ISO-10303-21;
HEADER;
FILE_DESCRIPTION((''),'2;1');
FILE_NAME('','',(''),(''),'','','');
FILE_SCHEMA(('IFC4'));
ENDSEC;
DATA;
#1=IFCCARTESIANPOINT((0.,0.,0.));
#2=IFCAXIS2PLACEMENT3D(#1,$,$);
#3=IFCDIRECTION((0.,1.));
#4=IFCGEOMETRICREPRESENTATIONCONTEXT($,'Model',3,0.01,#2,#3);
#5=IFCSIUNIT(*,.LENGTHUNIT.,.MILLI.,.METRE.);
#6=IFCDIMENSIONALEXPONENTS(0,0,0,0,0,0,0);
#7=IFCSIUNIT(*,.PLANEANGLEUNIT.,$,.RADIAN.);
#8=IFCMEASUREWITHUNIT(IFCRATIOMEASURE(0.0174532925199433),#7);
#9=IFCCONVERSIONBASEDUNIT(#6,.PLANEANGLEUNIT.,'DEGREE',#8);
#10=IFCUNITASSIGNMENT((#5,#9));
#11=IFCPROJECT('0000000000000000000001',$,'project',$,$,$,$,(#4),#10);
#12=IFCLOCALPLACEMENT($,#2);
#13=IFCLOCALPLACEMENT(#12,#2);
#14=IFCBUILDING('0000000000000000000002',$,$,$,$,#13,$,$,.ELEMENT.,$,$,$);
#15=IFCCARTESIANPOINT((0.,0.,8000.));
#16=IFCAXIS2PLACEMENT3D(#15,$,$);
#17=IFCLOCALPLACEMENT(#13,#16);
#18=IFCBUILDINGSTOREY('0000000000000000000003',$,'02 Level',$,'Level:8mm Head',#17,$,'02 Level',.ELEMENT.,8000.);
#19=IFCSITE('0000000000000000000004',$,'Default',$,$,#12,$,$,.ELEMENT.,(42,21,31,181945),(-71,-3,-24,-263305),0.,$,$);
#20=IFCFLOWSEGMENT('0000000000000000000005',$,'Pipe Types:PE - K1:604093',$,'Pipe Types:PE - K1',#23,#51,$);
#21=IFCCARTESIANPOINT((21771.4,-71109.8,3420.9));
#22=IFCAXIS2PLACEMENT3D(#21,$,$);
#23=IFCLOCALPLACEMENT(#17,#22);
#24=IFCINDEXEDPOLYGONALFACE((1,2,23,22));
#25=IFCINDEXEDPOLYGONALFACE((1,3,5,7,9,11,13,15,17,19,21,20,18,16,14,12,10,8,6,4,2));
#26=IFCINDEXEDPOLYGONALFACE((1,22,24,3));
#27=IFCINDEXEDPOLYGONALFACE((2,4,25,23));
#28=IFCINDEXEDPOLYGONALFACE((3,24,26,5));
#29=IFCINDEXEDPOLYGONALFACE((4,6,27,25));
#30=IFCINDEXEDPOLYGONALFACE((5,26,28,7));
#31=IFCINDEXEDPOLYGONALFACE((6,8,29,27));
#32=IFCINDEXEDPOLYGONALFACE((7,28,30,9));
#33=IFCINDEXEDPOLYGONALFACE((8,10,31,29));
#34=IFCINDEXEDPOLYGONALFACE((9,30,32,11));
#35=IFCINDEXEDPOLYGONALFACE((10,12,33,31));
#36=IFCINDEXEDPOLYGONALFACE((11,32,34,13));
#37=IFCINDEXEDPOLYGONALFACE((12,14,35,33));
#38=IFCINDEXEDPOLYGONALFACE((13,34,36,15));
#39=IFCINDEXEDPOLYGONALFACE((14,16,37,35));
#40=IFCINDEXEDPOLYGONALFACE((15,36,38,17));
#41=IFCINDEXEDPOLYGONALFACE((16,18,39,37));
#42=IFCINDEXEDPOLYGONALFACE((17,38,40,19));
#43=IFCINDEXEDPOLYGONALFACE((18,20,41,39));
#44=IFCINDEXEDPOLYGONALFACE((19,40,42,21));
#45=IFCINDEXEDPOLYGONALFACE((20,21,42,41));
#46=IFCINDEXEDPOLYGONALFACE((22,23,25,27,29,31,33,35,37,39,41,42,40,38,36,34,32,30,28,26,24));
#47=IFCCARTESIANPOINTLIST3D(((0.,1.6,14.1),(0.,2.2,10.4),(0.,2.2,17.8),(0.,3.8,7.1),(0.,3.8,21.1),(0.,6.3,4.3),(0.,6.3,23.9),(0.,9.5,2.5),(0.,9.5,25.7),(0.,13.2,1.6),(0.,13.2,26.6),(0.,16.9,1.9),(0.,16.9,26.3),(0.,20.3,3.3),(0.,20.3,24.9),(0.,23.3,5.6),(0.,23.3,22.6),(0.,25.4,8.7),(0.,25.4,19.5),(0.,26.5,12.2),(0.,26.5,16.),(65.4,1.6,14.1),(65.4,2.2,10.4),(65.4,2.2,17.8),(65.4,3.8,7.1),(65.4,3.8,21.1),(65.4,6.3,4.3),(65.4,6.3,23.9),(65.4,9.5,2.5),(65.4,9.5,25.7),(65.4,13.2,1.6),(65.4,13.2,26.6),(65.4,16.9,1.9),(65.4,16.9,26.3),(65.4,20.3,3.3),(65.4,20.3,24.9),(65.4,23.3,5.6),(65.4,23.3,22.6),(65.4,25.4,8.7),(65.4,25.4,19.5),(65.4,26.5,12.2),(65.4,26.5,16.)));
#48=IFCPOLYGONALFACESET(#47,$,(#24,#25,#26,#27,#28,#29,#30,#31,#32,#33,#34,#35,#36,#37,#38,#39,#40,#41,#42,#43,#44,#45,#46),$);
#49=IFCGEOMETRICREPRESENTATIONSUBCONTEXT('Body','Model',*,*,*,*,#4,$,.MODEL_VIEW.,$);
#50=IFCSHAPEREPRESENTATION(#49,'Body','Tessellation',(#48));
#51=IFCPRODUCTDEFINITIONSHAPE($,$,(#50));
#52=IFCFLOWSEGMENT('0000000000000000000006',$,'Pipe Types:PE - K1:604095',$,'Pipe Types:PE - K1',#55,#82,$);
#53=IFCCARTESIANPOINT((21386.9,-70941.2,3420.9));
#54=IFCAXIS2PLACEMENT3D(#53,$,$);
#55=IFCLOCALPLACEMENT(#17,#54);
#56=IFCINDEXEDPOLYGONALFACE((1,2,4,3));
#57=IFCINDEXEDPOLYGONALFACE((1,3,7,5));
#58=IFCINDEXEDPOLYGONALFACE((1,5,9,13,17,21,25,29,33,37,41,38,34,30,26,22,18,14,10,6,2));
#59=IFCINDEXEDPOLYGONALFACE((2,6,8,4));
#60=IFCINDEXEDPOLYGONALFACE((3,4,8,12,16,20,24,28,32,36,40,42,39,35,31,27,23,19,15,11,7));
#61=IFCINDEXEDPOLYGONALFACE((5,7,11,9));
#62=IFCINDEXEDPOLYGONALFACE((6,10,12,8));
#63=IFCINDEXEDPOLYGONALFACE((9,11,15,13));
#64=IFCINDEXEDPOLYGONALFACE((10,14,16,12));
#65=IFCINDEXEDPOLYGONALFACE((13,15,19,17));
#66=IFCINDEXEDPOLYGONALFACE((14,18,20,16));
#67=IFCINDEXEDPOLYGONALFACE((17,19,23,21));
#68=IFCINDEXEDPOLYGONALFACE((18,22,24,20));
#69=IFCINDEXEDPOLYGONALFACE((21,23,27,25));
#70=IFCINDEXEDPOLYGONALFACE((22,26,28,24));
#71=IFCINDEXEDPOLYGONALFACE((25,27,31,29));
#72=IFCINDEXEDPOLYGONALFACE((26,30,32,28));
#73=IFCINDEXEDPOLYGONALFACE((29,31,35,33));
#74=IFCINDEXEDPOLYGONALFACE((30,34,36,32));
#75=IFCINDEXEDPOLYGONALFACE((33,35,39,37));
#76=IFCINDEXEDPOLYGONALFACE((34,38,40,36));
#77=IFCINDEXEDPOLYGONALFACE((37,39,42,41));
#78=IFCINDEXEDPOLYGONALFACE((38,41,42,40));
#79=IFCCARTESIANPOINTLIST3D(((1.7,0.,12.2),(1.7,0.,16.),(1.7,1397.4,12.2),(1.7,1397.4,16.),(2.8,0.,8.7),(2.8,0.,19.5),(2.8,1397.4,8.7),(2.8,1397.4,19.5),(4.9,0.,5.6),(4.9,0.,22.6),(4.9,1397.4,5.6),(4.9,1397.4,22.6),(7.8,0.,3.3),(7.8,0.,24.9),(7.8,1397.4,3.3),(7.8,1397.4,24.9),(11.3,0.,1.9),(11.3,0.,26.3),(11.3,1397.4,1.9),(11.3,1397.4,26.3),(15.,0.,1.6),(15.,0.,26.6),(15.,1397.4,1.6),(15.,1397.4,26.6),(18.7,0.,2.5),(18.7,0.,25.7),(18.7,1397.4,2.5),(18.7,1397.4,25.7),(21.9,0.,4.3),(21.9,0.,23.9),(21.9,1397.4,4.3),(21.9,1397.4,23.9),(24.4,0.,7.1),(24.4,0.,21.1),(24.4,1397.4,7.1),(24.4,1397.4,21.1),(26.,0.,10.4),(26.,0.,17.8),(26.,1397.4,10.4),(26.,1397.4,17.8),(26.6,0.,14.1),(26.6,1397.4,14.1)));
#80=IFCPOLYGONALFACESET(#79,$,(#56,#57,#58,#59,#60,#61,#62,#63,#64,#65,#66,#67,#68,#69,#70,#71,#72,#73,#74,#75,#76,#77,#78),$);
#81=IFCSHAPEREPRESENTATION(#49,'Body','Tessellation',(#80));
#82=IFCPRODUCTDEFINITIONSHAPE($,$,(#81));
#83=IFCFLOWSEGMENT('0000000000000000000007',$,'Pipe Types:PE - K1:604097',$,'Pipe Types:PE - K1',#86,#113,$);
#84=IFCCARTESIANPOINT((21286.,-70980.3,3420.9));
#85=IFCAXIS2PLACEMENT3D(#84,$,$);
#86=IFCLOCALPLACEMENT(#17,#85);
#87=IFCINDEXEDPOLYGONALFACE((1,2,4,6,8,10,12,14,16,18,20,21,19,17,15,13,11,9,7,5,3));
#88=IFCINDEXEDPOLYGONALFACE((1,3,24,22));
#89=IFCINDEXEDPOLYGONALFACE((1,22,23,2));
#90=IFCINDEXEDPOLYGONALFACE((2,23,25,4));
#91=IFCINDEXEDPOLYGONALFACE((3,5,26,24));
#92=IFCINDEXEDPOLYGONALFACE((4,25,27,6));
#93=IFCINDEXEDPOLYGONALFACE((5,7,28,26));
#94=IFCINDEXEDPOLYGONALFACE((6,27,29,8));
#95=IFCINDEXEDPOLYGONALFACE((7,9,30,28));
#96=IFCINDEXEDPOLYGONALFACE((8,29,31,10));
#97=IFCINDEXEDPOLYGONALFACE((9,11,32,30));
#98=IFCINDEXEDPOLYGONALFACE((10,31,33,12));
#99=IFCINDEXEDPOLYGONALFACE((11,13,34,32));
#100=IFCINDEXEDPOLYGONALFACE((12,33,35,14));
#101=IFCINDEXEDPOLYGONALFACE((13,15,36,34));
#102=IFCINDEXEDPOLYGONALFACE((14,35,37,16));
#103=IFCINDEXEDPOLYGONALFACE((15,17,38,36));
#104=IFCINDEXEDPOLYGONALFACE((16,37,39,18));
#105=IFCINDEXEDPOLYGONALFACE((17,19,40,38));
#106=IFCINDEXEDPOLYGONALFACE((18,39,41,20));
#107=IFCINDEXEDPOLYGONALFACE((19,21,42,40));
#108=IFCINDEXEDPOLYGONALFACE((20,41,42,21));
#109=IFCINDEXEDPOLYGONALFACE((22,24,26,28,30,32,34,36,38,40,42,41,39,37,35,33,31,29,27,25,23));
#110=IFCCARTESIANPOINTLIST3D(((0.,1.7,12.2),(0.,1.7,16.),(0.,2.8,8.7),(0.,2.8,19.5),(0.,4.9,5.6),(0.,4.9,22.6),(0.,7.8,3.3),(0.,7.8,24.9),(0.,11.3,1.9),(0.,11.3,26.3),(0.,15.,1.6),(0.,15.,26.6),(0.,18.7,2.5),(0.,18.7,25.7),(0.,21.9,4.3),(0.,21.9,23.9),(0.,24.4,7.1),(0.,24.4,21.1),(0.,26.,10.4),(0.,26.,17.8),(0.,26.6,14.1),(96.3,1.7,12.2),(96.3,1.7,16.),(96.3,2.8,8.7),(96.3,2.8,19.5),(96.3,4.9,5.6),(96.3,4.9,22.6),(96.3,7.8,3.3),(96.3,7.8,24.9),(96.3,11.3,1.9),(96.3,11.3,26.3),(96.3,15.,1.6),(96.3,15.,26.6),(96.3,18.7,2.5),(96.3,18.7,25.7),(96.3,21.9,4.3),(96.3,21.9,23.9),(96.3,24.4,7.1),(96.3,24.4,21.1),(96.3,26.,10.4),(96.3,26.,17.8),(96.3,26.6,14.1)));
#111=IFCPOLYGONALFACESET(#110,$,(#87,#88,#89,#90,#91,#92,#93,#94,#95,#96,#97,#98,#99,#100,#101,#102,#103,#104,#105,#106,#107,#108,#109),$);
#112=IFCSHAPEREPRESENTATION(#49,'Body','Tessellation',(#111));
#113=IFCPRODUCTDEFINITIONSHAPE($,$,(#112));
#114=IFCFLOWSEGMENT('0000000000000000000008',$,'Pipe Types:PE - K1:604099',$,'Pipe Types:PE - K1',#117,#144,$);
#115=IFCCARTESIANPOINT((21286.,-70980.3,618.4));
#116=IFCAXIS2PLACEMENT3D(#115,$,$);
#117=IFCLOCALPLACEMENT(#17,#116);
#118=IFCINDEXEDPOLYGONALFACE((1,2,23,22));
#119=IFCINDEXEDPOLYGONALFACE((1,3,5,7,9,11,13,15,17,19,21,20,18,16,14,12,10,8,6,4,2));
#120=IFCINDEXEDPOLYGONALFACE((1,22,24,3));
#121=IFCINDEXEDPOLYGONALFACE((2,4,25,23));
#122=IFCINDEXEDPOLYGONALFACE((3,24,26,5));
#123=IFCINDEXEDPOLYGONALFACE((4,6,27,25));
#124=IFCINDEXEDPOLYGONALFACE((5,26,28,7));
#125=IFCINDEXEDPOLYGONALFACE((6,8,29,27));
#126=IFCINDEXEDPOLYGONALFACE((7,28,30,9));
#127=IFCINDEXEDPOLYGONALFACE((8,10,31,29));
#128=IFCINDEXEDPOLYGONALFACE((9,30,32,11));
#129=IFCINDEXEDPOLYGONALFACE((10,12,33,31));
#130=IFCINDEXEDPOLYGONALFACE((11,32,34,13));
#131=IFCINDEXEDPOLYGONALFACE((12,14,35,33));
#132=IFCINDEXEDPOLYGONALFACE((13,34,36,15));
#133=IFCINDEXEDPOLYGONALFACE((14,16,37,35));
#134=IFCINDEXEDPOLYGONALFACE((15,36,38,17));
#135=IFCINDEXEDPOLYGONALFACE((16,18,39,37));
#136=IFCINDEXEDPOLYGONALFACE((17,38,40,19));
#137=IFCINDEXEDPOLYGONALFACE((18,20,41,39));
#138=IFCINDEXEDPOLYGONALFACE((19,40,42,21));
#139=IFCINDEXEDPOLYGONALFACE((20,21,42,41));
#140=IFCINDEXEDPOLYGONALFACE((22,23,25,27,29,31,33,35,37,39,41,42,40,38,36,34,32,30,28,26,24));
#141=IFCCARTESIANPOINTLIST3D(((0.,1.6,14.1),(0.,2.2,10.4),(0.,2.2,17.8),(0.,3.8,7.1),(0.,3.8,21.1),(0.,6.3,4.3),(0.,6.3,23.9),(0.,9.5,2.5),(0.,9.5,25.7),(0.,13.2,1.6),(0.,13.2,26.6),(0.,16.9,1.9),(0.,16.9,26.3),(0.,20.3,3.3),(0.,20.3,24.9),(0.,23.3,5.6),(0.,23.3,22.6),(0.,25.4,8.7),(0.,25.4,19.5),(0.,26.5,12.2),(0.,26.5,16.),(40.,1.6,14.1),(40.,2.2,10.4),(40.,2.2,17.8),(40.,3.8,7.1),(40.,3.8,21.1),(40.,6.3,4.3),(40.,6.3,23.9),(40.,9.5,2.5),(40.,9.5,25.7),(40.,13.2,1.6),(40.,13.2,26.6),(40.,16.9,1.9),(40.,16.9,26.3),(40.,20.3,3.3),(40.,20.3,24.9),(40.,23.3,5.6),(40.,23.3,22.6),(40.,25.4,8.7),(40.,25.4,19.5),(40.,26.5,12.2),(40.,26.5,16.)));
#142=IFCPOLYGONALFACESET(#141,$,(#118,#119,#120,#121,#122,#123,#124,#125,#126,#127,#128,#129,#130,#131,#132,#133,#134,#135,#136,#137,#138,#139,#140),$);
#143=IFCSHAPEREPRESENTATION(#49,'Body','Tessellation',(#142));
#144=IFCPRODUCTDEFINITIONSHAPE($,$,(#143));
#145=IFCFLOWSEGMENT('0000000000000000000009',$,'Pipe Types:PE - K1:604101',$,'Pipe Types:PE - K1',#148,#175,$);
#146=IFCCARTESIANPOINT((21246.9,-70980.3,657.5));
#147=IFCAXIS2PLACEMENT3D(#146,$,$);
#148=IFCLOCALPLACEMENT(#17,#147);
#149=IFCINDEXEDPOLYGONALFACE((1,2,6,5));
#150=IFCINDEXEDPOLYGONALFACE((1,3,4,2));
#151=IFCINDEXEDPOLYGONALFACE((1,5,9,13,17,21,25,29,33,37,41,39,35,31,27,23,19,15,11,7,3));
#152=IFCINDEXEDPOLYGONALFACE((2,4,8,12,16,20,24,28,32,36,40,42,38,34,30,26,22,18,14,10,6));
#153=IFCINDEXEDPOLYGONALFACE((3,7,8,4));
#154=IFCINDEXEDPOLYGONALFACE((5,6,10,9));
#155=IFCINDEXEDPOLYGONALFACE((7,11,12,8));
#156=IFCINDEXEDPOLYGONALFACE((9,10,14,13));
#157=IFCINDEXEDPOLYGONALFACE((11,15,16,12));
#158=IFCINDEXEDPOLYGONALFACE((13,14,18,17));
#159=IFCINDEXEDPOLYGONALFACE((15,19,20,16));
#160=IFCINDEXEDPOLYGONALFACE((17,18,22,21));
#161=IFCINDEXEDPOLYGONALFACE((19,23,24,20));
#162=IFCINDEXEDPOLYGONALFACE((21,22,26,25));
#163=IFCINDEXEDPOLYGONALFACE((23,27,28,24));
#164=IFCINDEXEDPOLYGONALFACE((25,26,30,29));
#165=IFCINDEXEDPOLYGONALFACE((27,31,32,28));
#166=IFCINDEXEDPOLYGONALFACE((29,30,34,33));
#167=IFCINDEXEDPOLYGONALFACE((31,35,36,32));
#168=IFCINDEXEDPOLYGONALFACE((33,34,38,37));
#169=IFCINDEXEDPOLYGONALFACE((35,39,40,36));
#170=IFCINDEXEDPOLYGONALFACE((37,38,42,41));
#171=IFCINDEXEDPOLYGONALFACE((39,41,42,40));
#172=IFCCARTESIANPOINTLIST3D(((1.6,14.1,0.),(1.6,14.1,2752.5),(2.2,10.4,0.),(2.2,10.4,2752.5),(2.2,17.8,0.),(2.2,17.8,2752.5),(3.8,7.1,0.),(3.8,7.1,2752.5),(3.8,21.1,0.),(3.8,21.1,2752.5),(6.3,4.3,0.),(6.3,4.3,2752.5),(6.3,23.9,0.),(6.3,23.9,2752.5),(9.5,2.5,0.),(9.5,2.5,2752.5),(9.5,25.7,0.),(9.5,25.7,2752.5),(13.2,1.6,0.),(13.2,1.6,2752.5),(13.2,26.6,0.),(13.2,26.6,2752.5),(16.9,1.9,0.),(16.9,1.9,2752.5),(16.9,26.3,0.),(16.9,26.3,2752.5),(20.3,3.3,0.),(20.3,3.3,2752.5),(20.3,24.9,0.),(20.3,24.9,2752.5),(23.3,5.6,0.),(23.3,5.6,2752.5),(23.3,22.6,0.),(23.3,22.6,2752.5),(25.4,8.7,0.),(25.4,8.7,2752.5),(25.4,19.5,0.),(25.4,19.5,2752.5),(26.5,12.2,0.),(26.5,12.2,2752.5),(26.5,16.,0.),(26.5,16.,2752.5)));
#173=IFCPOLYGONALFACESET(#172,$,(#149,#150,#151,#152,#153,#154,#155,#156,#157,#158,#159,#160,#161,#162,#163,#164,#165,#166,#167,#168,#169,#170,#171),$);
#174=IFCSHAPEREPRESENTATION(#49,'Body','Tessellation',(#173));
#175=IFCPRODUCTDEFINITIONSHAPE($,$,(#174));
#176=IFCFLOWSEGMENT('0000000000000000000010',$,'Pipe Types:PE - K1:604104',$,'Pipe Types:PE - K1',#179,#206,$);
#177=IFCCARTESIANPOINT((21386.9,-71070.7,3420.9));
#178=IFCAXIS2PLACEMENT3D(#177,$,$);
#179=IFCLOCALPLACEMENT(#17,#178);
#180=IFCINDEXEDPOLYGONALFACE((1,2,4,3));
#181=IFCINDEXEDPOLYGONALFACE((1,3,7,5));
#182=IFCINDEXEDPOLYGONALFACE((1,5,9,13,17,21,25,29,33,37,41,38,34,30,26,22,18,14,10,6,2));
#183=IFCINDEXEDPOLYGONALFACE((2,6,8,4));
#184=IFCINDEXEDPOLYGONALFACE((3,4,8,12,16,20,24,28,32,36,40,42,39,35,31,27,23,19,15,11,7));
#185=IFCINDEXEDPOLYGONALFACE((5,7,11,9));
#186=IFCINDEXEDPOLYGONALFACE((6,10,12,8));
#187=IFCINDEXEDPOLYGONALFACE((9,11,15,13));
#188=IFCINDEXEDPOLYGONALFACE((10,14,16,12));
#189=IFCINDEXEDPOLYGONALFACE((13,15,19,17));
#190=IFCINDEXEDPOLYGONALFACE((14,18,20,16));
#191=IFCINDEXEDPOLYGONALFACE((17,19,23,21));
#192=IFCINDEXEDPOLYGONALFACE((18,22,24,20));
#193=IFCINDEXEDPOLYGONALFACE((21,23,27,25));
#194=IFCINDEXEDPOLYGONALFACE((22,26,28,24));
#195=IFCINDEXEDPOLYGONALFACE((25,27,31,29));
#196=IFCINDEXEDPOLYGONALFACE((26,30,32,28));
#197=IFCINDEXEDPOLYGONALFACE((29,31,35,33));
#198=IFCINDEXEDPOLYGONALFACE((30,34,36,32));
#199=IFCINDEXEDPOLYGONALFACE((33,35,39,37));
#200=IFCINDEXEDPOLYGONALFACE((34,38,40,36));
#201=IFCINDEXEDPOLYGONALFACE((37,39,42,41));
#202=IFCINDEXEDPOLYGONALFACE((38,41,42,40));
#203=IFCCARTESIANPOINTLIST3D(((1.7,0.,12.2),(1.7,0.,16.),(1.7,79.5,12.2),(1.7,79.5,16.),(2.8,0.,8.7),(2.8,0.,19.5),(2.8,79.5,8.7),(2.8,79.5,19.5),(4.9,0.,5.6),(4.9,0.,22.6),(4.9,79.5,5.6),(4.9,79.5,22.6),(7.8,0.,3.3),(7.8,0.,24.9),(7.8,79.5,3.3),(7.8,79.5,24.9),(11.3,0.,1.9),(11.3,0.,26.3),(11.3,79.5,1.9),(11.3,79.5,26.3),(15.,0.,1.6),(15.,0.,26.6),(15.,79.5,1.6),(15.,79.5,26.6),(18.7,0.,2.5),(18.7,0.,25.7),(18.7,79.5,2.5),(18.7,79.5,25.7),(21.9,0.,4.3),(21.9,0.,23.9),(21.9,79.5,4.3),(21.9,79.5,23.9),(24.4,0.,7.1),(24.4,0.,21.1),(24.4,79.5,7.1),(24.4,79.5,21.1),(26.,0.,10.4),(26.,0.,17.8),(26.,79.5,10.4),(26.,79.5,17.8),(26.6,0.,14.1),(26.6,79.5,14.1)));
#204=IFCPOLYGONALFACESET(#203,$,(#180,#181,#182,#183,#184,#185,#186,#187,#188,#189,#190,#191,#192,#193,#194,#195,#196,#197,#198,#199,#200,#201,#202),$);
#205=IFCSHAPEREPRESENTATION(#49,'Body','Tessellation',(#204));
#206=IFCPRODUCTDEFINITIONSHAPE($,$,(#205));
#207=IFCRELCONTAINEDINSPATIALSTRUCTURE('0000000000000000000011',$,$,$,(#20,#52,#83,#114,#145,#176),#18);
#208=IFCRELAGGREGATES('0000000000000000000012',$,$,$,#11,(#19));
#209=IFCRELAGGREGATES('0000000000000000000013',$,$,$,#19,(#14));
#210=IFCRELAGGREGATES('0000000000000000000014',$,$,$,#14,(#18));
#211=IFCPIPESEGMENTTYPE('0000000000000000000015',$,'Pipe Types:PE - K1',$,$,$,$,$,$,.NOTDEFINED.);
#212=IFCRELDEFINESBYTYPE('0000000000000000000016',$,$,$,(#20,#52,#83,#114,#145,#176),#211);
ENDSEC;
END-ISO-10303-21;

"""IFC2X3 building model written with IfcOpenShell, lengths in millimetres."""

from ifc_helpers import new_model, entity, si_unit, converted_unit, direction, frame, frame_2d, origin, origin_2d_with_axis, place, context, subcontext, project, spatial, circle, extrude, type_object, element, save


model = new_model("IFC2X3")

# Units and contexts
model_context = context("Model", 3, precision=0.01, world=origin(), true_north=direction((0.0, 1.0)))
body_context = subcontext(model_context, "Body", "Model", "MODEL_VIEW")
ifc_project = project(units=[si_unit("LENGTHUNIT", "METRE", prefix="MILLI"), converted_unit("PLANEANGLEUNIT", "DEGREE", entity("IfcRatioMeasure", 0.0174532925199433), si_unit("PLANEANGLEUNIT", "RADIAN"), dimensions=[0, 0, 0, 0, 0, 0, 0])], contexts=[model_context])

# Site, building, storey
site_placement = place(None, origin())
site = spatial("IfcSite", under=ifc_project, at=site_placement, Name="Default", CompositionType="ELEMENT", RefLatitude=(42, 21, 31, 181945), RefLongitude=(-71, -3, -24, -263305), RefElevation=0.0)
building_placement = place(site_placement, origin())
building = spatial("IfcBuilding", under=site, at=building_placement, CompositionType="ELEMENT")
storey_placement = place(building_placement, frame((0.0, 0.0, 8000.0)))
storey = spatial("IfcBuildingStorey", under=building, at=storey_placement, Name="02 Level", ObjectType="Level:8mm Head", LongName="02 Level", CompositionType="ELEMENT", Elevation=8000.0)

# Flow segments
pipe_segment_type = type_object("IfcPipeSegmentType", Name="Pipe Types:PE - K1", PredefinedType="NOTDEFINED")
flow_segment_1_placement = place(storey_placement, frame((21771.4, -71109.8, 3420.9)))
element("IfcFlowSegment", 1, at=flow_segment_1_placement, inside=storey, type_object=pipe_segment_type, Name="Pipe Types:PE - K1:604093", ObjectType="Pipe Types:PE - K1", context=body_context, shape_type="SweptSolid", body=[
    extrude(circle(Radius=12.5, at=origin_2d_with_axis()), frame((0.0, 14.1, 14.1), z_axis=(1.0, 0.0, 0.0), x_axis=(0.0, -1.0, 0.0)), (0.0, 0.0, 1.0), 65.4),
])
flow_segment_2_placement = place(storey_placement, frame((21386.9, -70941.2, 3420.9)))
element("IfcFlowSegment", 2, at=flow_segment_2_placement, inside=storey, type_object=pipe_segment_type, Name="Pipe Types:PE - K1:604095", ObjectType="Pipe Types:PE - K1", context=body_context, shape_type="SweptSolid", body=[
    extrude(circle(Radius=12.5, at=origin_2d_with_axis()), frame((14.1, 0.0, 14.1), z_axis=(0.0, 1.0, 0.0), x_axis=(1.0, 0.0, 0.0)), (0.0, 0.0, 1.0), 1397.4),
])
flow_segment_3_placement = place(storey_placement, frame((21286.0, -70980.3, 3420.9)))
element("IfcFlowSegment", 3, at=flow_segment_3_placement, inside=storey, type_object=pipe_segment_type, Name="Pipe Types:PE - K1:604097", ObjectType="Pipe Types:PE - K1", context=body_context, shape_type="SweptSolid", body=[
    extrude(circle(Radius=12.5, at=origin_2d_with_axis()), frame((0.0, 14.1, 14.1), z_axis=(1.0, 0.0, 0.0), x_axis=(0.0, 1.0, 0.0)), (0.0, 0.0, 1.0), 96.3),
])
flow_segment_4_placement = place(storey_placement, frame((21286.0, -70980.3, 618.4)))
element("IfcFlowSegment", 4, at=flow_segment_4_placement, inside=storey, type_object=pipe_segment_type, Name="Pipe Types:PE - K1:604099", ObjectType="Pipe Types:PE - K1", context=body_context, shape_type="SweptSolid", body=[
    extrude(circle(Radius=12.5, at=frame_2d((0.0, 0.0), x_axis=(1.0, 0.0))), frame((0.0, 14.1, 14.1), z_axis=(1.0, 0.0, 0.0), x_axis=(0.0, -1.0, 0.0)), (0.0, 0.0, 1.0), 40.0),
])
flow_segment_5_placement = place(storey_placement, frame((21246.9, -70980.3, 657.5)))
element("IfcFlowSegment", 5, at=flow_segment_5_placement, inside=storey, type_object=pipe_segment_type, Name="Pipe Types:PE - K1:604101", ObjectType="Pipe Types:PE - K1", context=body_context, shape_type="SweptSolid", body=[
    extrude(circle(Radius=12.5, at=frame_2d((0.0, 0.0), x_axis=(1.0, 0.0))), frame((14.1, 14.1, 0.0), z_axis=(0.0, 0.0, 1.0), x_axis=(-1.0, 0.0, 0.0)), (0.0, 0.0, 1.0), 2752.5),
])
flow_segment_6_placement = place(storey_placement, frame((21386.9, -71070.7, 3420.9)))
element("IfcFlowSegment", 6, at=flow_segment_6_placement, inside=storey, type_object=pipe_segment_type, Name="Pipe Types:PE - K1:604104", ObjectType="Pipe Types:PE - K1", context=body_context, shape_type="SweptSolid", body=[
    extrude(circle(Radius=12.5, at=origin_2d_with_axis()), frame((14.1, 0.0, 14.1), z_axis=(0.0, 1.0, 0.0), x_axis=(1.0, 0.0, 0.0)), (0.0, 0.0, 1.0), 79.5),
])

save(model, "model.ifc")
